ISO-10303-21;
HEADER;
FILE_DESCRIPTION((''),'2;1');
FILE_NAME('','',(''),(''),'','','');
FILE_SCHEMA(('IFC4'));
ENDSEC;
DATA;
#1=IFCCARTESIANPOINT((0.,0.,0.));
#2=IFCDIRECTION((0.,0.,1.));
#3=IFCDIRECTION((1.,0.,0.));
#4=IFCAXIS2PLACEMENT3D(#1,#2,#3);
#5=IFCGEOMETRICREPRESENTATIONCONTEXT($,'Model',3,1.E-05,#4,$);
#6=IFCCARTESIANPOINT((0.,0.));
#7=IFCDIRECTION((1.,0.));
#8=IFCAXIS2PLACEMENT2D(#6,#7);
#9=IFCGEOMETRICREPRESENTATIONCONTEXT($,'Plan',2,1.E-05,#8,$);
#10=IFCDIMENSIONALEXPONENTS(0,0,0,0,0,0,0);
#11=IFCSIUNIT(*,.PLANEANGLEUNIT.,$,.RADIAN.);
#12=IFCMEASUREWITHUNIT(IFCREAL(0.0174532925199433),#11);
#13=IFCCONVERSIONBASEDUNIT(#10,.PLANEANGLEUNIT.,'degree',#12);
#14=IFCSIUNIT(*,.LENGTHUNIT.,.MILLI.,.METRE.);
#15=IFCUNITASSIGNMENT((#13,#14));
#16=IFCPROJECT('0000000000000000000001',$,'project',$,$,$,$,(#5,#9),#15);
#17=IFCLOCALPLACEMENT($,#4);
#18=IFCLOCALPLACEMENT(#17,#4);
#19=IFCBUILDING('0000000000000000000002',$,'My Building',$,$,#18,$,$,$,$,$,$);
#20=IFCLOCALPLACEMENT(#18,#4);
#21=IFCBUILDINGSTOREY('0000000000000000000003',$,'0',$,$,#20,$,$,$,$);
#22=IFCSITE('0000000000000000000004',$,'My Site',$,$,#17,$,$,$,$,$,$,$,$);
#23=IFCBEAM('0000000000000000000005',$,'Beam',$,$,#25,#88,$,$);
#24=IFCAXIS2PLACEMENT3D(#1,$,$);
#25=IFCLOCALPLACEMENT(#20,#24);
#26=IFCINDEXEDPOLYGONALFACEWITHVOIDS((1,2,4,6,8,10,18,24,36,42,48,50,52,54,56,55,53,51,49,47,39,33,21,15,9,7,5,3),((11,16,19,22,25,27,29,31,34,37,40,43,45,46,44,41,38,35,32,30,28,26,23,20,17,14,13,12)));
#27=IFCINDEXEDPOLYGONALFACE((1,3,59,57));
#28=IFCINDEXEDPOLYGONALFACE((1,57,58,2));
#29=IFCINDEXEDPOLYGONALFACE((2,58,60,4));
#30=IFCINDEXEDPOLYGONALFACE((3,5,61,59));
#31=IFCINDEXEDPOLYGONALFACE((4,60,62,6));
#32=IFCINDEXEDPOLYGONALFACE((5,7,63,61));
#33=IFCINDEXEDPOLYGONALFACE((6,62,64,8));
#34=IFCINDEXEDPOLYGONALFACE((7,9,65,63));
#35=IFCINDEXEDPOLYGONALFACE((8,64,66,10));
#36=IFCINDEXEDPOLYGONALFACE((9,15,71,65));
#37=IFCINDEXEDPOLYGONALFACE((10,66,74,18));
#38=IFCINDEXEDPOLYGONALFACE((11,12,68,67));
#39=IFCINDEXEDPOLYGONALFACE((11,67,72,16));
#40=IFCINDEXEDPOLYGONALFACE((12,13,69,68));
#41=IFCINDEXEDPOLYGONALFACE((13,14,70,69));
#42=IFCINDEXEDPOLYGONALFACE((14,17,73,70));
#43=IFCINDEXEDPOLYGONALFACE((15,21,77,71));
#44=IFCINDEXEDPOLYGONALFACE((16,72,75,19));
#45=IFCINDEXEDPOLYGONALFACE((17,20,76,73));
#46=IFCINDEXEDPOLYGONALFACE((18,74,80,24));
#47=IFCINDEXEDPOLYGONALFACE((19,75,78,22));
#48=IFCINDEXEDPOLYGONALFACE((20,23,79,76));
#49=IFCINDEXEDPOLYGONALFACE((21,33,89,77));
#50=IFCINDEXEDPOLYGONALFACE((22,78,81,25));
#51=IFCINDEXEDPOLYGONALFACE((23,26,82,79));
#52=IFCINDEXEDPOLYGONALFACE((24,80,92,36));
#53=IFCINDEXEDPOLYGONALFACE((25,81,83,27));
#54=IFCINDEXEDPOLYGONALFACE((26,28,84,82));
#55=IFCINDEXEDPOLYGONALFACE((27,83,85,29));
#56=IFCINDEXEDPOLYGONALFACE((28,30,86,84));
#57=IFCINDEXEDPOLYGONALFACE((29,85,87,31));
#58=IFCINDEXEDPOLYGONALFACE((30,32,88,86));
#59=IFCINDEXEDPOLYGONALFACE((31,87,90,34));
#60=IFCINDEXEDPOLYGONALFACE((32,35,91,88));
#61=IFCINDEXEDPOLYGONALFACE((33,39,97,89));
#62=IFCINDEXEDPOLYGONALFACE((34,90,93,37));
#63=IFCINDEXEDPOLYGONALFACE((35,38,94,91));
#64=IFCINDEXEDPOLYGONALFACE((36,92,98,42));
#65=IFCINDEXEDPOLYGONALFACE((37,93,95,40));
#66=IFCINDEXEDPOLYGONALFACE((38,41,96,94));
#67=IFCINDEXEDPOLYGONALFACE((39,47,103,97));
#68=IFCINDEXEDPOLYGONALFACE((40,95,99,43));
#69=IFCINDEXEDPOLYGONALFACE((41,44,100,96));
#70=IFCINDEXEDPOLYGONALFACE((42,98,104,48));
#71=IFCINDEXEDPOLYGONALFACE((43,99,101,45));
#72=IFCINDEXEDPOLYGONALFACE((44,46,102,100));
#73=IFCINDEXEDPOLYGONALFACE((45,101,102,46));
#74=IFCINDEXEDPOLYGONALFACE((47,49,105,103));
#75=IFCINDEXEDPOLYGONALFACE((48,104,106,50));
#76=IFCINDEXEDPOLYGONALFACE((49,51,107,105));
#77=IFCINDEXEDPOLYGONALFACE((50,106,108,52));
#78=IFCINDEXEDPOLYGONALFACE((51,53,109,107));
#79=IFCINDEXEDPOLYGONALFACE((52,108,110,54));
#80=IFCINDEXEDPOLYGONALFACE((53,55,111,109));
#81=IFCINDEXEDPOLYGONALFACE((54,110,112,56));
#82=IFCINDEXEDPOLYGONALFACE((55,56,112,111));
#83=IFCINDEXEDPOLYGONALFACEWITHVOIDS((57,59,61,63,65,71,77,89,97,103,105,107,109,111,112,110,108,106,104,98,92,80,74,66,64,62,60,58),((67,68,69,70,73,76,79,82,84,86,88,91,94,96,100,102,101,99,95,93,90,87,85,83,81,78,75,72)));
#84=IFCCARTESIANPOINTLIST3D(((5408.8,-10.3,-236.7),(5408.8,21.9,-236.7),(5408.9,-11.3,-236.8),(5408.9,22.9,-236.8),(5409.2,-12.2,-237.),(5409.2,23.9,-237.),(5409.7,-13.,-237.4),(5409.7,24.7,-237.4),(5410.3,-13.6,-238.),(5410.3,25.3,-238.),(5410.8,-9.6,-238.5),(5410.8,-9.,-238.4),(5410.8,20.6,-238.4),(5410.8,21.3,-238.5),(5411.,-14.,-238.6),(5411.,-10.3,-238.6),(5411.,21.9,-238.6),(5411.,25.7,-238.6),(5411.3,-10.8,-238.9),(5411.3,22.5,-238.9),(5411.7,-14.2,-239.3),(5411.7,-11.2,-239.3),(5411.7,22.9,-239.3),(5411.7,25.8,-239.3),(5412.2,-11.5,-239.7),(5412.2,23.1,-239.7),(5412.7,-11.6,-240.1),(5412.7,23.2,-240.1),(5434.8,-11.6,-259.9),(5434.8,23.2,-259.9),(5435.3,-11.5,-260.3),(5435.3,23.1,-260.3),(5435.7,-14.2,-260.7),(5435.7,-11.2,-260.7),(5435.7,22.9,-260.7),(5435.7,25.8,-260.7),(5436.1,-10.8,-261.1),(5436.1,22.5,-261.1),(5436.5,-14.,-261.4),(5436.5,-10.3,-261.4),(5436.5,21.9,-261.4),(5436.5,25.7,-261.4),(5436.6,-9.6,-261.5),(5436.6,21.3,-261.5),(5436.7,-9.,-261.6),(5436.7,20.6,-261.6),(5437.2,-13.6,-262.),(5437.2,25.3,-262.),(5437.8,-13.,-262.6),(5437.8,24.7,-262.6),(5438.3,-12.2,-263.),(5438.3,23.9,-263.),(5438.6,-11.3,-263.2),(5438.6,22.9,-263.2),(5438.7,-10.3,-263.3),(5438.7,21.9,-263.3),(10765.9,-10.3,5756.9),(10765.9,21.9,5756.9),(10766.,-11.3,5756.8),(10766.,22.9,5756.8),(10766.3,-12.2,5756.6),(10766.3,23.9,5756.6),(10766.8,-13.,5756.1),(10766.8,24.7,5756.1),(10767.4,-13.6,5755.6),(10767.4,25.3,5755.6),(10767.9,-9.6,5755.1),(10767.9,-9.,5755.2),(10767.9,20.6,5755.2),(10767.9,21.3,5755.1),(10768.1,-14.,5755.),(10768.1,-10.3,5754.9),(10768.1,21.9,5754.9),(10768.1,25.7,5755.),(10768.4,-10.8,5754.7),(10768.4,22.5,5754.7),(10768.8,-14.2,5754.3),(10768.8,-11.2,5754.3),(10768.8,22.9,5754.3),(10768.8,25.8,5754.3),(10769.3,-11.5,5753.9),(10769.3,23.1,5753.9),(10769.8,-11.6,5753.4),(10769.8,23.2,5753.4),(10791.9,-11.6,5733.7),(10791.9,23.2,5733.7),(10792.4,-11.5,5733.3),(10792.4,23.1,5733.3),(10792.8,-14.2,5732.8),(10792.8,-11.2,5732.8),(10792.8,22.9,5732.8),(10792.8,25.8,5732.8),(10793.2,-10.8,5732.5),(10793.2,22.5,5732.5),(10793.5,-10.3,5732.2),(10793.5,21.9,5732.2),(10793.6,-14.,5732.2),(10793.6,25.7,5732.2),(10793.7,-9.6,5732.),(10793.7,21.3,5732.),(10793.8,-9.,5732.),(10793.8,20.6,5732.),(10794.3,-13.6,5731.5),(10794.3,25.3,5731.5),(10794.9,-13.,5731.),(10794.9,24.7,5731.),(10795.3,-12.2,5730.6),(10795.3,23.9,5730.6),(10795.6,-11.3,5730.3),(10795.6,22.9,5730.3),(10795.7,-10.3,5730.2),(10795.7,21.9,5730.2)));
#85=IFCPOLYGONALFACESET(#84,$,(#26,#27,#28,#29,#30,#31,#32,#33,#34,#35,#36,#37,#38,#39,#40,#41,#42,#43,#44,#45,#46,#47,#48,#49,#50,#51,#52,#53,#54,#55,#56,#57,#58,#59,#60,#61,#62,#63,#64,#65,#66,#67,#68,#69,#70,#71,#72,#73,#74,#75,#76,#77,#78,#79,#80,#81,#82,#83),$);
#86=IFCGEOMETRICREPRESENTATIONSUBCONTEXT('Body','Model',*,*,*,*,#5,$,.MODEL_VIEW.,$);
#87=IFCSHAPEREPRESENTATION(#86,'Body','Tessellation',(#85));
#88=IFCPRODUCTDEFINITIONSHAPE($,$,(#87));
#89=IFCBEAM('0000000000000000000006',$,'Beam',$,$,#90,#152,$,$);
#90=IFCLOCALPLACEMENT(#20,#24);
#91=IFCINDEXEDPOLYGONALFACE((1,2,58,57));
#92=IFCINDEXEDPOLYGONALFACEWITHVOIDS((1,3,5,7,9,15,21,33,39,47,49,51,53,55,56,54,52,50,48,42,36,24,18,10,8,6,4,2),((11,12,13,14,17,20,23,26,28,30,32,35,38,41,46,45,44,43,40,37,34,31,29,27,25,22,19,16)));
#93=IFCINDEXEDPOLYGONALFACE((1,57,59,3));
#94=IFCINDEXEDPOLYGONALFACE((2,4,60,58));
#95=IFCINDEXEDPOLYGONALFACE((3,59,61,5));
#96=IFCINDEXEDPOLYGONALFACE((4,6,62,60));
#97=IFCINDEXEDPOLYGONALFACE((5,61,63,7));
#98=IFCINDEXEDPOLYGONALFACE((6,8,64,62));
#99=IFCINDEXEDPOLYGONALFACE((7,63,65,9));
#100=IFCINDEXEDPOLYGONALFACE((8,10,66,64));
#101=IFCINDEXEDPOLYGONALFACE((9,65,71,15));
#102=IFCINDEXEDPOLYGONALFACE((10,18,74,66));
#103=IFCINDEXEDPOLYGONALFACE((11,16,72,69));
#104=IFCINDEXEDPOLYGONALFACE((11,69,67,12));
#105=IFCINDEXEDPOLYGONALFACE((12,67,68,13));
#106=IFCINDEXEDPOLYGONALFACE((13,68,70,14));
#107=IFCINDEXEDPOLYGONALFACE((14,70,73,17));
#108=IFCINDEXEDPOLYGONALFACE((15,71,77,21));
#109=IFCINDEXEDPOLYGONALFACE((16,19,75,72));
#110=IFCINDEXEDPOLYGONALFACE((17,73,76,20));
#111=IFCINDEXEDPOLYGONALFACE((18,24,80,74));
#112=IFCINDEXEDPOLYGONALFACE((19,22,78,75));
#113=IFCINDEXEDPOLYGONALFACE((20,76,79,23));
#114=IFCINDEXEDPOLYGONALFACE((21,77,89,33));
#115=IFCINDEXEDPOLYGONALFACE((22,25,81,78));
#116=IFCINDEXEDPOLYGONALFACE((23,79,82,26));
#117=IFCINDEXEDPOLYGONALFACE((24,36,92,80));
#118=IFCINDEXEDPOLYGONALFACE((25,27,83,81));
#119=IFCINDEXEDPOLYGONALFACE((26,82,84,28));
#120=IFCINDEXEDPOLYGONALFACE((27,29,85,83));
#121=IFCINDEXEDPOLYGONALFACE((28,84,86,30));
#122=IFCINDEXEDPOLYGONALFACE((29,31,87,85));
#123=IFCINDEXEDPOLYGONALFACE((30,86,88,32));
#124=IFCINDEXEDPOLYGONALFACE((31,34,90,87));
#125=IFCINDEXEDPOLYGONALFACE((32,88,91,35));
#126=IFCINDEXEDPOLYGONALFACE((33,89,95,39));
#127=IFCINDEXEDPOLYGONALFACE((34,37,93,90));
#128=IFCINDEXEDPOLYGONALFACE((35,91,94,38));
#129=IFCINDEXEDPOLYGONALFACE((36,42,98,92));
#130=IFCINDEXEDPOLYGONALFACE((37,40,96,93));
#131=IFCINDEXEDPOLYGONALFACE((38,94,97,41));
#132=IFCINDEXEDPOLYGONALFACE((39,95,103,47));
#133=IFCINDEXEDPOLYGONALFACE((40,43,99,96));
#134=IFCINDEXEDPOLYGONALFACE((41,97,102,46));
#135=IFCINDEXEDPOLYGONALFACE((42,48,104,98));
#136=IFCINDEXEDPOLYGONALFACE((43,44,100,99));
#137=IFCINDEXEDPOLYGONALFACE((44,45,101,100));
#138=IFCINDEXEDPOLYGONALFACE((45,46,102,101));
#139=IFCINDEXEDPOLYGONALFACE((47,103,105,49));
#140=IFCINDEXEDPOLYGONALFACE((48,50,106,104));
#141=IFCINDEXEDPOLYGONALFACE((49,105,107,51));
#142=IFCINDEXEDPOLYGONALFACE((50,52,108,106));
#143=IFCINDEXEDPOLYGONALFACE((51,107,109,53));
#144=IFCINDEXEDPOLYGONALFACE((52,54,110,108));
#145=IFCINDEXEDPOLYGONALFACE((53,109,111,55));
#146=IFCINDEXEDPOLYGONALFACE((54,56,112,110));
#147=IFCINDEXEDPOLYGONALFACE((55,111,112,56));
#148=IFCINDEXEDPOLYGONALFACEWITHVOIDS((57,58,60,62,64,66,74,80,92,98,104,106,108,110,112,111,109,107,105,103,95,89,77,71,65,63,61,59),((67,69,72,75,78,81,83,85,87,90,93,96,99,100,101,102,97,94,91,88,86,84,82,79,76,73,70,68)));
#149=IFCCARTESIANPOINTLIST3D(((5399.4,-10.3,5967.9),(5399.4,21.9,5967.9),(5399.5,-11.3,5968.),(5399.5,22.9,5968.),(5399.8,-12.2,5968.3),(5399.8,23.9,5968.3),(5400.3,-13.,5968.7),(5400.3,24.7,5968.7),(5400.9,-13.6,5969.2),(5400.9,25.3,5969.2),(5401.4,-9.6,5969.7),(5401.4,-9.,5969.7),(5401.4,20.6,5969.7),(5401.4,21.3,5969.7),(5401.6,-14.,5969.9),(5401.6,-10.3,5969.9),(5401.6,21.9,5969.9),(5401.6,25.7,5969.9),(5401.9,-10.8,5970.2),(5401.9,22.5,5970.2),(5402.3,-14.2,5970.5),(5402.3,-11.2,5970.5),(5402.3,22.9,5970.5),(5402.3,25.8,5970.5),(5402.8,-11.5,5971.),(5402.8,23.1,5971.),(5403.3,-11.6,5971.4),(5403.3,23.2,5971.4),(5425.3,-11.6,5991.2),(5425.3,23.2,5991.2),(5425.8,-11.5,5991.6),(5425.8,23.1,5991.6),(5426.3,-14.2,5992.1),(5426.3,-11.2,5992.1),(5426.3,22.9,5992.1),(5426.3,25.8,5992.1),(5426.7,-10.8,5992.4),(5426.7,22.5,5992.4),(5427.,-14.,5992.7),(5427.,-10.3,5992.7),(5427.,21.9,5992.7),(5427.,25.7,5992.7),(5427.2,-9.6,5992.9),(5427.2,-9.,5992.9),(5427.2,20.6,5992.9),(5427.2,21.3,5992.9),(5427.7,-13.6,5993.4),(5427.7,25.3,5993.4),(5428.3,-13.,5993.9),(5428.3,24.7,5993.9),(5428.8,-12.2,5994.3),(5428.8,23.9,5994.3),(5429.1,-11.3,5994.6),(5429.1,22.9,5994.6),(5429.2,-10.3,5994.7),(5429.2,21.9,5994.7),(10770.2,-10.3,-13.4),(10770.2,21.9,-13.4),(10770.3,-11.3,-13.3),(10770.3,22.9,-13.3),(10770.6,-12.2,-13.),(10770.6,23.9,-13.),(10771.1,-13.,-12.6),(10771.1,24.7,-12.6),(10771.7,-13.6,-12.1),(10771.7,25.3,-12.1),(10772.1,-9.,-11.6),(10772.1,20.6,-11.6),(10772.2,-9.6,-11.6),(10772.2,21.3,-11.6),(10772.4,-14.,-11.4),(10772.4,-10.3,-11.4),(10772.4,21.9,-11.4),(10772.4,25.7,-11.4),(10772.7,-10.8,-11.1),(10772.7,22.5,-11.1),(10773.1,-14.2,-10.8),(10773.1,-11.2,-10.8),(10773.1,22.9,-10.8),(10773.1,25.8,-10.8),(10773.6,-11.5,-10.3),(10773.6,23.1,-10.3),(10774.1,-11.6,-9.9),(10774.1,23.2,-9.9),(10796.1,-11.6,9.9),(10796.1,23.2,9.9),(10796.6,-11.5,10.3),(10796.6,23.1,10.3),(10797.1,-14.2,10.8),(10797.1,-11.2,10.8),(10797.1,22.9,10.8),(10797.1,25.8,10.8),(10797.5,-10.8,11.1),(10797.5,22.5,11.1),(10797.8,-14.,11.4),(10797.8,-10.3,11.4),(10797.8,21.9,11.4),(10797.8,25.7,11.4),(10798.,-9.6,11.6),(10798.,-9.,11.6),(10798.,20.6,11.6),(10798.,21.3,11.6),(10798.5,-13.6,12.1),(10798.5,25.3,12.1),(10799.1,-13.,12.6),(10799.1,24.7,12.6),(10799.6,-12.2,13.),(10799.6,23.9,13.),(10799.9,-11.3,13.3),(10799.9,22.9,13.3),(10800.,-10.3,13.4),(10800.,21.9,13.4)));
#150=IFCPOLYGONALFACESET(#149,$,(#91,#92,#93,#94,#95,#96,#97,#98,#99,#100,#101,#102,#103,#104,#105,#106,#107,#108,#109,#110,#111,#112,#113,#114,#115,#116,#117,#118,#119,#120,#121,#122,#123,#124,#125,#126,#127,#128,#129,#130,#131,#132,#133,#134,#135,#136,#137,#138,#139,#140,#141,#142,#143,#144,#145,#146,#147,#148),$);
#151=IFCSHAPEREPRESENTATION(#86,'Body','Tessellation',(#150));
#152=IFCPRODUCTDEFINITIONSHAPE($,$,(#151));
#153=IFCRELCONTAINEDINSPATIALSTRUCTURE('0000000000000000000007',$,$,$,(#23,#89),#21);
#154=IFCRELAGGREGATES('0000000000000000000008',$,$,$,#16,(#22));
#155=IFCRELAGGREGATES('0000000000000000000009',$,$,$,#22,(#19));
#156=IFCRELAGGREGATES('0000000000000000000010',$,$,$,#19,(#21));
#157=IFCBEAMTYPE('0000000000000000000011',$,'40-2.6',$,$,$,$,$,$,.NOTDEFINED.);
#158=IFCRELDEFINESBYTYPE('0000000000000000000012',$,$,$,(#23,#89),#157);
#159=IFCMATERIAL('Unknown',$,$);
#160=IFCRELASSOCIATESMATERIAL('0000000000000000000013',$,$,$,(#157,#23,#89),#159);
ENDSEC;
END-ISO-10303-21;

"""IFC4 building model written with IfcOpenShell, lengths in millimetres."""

from ifc_helpers import new_model, entity, si_unit, converted_unit, frame, origin_with_axes, origin_2d_with_axis, place, context, subcontext, project, spatial, hollow_rectangle, extrude, material, material_profile, profile_set, profile_usage, type_object, element, save


model = new_model("IFC4")

# Units and contexts
model_context = context("Model", 3, precision=1e-05, world=origin_with_axes())
plan_context = context("Plan", 2, precision=1e-05, world=origin_2d_with_axis())
body_context = subcontext(model_context, "Body", "Model", "MODEL_VIEW")
ifc_project = project(units=[converted_unit("PLANEANGLEUNIT", "degree", entity("IfcReal", 0.0174532925199433), si_unit("PLANEANGLEUNIT", "RADIAN"), dimensions=[0, 0, 0, 0, 0, 0, 0]), si_unit("LENGTHUNIT", "METRE", prefix="MILLI")], contexts=[model_context, plan_context])

# Site, building, storey
site_placement = place(None, origin_with_axes())
site = spatial("IfcSite", under=ifc_project, at=site_placement, Name="My Site")
building_placement = place(site_placement, origin_with_axes())
building = spatial("IfcBuilding", under=site, at=building_placement, Name="My Building")
storey_placement = place(building_placement, origin_with_axes())
storey = spatial("IfcBuildingStorey", under=building, at=storey_placement, Name="0")

# Shared definitions
ifc_material = material(Name="Unknown")

# Beams
ifc_material_profile_1 = material_profile(ifc_material, hollow_rectangle(XDim=40.0, YDim=40.0, WallThickness=2.6, InnerFilletRadius=2.6, OuterFilletRadius=3.9))
ifc_profile_set_1 = profile_set([ifc_material_profile_1])
ifc_profile_usage_1 = profile_usage(ifc_profile_set_1, cardinal=5)
beam_type = type_object("IfcBeamType", Name="40-2.6", PredefinedType="NOTDEFINED", material=ifc_profile_set_1)
beam_1_placement = place(storey_placement, frame((5423.7, 5.8, -250.0), z_axis=(0.666409, 0.0, 0.745587), x_axis=(0.0, 1.0, 0.0)))
element("IfcBeam", 1, at=beam_1_placement, inside=storey, type_object=beam_type, material=ifc_profile_usage_1, Name="Beam", context=body_context, shape_type="SweptSolid", body=[
    extrude(hollow_rectangle(XDim=40.0, YDim=40.0, WallThickness=2.6, InnerFilletRadius=2.6, OuterFilletRadius=3.9), origin_with_axes(), (0.0, 0.0, 1.0), 8038.7),
])
ifc_profile_usage_2 = profile_usage(ifc_profile_set_1, cardinal=5)
beam_2_placement = place(storey_placement, frame((10785.1, 5.8, 0.0), z_axis=(-0.668113, 0.0, 0.74406), x_axis=(0.0, 1.0, 0.0)))
element("IfcBeam", 2, at=beam_2_placement, inside=storey, type_object=beam_type, material=ifc_profile_usage_2, Name="Beam", context=body_context, shape_type="SweptSolid", body=[
    extrude(hollow_rectangle(XDim=40.0, YDim=40.0, WallThickness=2.6, InnerFilletRadius=2.6, OuterFilletRadius=3.9), origin_with_axes(), (0.0, 0.0, 1.0), 8038.7),
])

save(model, "model.ifc")
